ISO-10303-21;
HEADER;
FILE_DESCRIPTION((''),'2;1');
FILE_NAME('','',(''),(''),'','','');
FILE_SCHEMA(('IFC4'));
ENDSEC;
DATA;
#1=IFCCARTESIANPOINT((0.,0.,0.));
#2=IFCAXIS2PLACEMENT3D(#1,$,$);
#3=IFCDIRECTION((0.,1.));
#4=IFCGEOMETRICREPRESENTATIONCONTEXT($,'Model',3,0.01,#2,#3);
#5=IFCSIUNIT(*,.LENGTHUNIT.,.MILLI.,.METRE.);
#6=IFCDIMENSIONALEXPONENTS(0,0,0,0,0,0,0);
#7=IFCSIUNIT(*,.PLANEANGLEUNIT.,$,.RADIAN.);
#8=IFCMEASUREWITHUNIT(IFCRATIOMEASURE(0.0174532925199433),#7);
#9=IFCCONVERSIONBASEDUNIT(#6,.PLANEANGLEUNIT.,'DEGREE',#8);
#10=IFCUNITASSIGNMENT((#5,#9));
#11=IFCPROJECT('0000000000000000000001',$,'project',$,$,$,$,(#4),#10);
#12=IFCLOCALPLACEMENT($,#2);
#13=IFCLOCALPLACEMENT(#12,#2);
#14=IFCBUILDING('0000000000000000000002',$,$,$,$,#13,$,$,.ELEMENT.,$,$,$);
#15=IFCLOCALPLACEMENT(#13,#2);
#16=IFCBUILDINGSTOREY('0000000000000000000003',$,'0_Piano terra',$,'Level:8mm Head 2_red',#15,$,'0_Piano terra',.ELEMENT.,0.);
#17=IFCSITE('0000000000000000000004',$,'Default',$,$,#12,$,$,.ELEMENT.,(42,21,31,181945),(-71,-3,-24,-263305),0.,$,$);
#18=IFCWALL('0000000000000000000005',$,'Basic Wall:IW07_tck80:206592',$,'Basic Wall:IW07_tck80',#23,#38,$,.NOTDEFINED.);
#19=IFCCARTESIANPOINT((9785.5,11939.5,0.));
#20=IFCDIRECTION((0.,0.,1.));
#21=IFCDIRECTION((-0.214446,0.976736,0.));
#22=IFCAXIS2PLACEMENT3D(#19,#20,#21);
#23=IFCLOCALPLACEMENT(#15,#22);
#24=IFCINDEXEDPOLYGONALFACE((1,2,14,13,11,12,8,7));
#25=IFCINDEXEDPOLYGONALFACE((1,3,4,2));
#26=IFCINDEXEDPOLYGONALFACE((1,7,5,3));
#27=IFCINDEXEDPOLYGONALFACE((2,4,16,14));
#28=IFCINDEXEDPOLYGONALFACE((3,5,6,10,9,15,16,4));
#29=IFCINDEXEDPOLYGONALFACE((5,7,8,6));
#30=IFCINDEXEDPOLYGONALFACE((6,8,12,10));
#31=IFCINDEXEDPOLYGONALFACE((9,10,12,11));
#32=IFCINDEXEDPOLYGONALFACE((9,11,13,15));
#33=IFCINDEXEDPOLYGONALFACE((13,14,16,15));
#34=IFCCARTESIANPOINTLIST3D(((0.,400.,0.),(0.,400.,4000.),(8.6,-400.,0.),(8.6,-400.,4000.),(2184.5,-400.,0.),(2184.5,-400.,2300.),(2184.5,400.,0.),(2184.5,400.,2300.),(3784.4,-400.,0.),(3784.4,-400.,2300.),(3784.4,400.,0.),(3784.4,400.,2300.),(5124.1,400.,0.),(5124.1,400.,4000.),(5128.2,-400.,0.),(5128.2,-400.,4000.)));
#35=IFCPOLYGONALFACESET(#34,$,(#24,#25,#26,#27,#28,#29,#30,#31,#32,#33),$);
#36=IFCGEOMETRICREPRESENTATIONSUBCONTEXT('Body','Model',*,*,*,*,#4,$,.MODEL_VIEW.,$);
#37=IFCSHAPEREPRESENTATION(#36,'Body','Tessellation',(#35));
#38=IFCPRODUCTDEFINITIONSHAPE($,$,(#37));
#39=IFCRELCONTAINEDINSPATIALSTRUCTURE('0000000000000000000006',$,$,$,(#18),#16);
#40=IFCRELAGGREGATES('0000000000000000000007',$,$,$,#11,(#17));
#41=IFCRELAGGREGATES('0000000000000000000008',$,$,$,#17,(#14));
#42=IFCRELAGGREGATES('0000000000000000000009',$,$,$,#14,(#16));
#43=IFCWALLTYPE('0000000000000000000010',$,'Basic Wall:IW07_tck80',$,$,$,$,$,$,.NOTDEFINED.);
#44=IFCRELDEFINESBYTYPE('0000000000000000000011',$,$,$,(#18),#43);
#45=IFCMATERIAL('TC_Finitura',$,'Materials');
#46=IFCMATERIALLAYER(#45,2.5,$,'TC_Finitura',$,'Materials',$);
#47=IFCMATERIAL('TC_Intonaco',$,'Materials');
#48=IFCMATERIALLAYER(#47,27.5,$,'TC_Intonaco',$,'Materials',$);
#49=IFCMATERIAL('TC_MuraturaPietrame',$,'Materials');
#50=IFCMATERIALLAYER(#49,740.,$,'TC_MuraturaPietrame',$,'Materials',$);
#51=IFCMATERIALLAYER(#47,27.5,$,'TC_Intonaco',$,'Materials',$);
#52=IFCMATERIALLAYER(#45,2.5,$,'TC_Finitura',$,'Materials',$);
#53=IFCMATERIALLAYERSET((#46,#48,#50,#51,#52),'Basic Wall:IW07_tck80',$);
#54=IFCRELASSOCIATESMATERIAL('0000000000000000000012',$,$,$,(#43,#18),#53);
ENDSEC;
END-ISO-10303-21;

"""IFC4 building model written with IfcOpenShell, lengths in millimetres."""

from ifc_helpers import new_model, entity, si_unit, converted_unit, direction, frame, frame_2d, origin, place, context, subcontext, project, spatial, polyline, rectangle, outline, extrude, clip, bounded_halfspace, material, layer, layer_set, layer_usage, type_object, element, save


model = new_model("IFC4")

# Units and contexts
model_context = context("Model", 3, precision=0.01, world=origin(), true_north=direction((0.0, 1.0)))
body_context = subcontext(model_context, "Body", "Model", "MODEL_VIEW")
ifc_project = project(units=[si_unit("LENGTHUNIT", "METRE", prefix="MILLI"), converted_unit("PLANEANGLEUNIT", "DEGREE", entity("IfcRatioMeasure", 0.0174532925199433), si_unit("PLANEANGLEUNIT", "RADIAN"), dimensions=[0, 0, 0, 0, 0, 0, 0])], contexts=[model_context])

# Site, building, storey
site_placement = place(None, origin())
site = spatial("IfcSite", under=ifc_project, at=site_placement, Name="Default", CompositionType="ELEMENT", RefLatitude=(42, 21, 31, 181945), RefLongitude=(-71, -3, -24, -263305), RefElevation=0.0)
building_placement = place(site_placement, origin())
building = spatial("IfcBuilding", under=site, at=building_placement, CompositionType="ELEMENT")
storey_placement = place(building_placement, origin())
storey = spatial("IfcBuildingStorey", under=building, at=storey_placement, Name="0_Piano terra", ObjectType="Level:8mm Head 2_red", LongName="0_Piano terra", CompositionType="ELEMENT", Elevation=0.0)

# Shared definitions
ifc_material_1 = material(Name="TC_Finitura", Category="Materials")
ifc_material_2 = material(Name="TC_Intonaco", Category="Materials")
ifc_material_3 = material(Name="TC_MuraturaPietrame", Category="Materials")

# Wall, opening
ifc_layer_1 = layer(ifc_material_1, 2.5, Name="TC_Finitura", Category="Materials")
ifc_layer_2 = layer(ifc_material_2, 27.5, Name="TC_Intonaco", Category="Materials")
ifc_layer_3 = layer(ifc_material_3, 740.0, Name="TC_MuraturaPietrame", Category="Materials")
ifc_layer_4 = layer(ifc_material_2, 27.5, Name="TC_Intonaco", Category="Materials")
ifc_layer_5 = layer(ifc_material_1, 2.5, Name="TC_Finitura", Category="Materials")
ifc_layer_set_1 = layer_set([ifc_layer_1, ifc_layer_2, ifc_layer_3, ifc_layer_4, ifc_layer_5], Name="Basic Wall:IW07_tck80")
ifc_layer_usage_1 = layer_usage(ifc_layer_set_1, "AXIS2", "NEGATIVE", 400.0)
wall_type_1 = type_object("IfcWallType", Name="Basic Wall:IW07_tck80", PredefinedType="NOTDEFINED", material=ifc_layer_set_1)
wall_1_placement = place(storey_placement, frame((9785.5, 11939.5, 0.0), z_axis=(0.0, 0.0, 1.0), x_axis=(-0.214446, 0.976736, 0.0)))
wall_1 = element("IfcWall", 1, at=wall_1_placement, inside=storey, type_object=wall_type_1, material=ifc_layer_usage_1, Name="Basic Wall:IW07_tck80:206592", ObjectType="Basic Wall:IW07_tck80", PredefinedType="NOTDEFINED", context=body_context, shape_type="Clipping", body=[
    clip(extrude(outline(polyline([(8.6, -400.0), (684.2, -400.0), (1284.2, -400.0), (5128.2, -400.0), (5124.1, 400.0), (0.0, 400.0), (8.6, -400.0)])), origin(), (0.0, 0.0, 1.0), 4000.0), bounded_halfspace(frame((8.6, -400.0, 4000.0), z_axis=(0.0, 0.0, -1.0), x_axis=(-0.998048, -0.062458, 0.0)), True, frame((8.6, -400.0, 4000.0)), polyline([(0.0, 0.0), (675.6, 0.0), (1275.6, 0.0), (5119.5, 0.0), (5115.5, 800.0), (-8.6, 800.0), (0.0, 0.0)]))),
])
opening_1_placement = place(wall_1_placement, frame((2258.0, 735.1, 0.0)))
element("IfcOpeningElement", 2, at=opening_1_placement, cuts=wall_1, ObjectType="Opening", PredefinedType="OPENING", context=body_context, shape_type="SweptSolid", body=[
    extrude(rectangle(XDim=2300.0, YDim=1600.0, at=frame_2d((0.0, 0.0), x_axis=(1.0, 0.0))), frame((726.4, -1135.1, 1150.0), z_axis=(0.0, 1.0, 0.0), x_axis=(0.0, 0.0, -1.0)), (0.0, 0.0, 1.0), 800.0),
])

save(model, "model.ifc")
